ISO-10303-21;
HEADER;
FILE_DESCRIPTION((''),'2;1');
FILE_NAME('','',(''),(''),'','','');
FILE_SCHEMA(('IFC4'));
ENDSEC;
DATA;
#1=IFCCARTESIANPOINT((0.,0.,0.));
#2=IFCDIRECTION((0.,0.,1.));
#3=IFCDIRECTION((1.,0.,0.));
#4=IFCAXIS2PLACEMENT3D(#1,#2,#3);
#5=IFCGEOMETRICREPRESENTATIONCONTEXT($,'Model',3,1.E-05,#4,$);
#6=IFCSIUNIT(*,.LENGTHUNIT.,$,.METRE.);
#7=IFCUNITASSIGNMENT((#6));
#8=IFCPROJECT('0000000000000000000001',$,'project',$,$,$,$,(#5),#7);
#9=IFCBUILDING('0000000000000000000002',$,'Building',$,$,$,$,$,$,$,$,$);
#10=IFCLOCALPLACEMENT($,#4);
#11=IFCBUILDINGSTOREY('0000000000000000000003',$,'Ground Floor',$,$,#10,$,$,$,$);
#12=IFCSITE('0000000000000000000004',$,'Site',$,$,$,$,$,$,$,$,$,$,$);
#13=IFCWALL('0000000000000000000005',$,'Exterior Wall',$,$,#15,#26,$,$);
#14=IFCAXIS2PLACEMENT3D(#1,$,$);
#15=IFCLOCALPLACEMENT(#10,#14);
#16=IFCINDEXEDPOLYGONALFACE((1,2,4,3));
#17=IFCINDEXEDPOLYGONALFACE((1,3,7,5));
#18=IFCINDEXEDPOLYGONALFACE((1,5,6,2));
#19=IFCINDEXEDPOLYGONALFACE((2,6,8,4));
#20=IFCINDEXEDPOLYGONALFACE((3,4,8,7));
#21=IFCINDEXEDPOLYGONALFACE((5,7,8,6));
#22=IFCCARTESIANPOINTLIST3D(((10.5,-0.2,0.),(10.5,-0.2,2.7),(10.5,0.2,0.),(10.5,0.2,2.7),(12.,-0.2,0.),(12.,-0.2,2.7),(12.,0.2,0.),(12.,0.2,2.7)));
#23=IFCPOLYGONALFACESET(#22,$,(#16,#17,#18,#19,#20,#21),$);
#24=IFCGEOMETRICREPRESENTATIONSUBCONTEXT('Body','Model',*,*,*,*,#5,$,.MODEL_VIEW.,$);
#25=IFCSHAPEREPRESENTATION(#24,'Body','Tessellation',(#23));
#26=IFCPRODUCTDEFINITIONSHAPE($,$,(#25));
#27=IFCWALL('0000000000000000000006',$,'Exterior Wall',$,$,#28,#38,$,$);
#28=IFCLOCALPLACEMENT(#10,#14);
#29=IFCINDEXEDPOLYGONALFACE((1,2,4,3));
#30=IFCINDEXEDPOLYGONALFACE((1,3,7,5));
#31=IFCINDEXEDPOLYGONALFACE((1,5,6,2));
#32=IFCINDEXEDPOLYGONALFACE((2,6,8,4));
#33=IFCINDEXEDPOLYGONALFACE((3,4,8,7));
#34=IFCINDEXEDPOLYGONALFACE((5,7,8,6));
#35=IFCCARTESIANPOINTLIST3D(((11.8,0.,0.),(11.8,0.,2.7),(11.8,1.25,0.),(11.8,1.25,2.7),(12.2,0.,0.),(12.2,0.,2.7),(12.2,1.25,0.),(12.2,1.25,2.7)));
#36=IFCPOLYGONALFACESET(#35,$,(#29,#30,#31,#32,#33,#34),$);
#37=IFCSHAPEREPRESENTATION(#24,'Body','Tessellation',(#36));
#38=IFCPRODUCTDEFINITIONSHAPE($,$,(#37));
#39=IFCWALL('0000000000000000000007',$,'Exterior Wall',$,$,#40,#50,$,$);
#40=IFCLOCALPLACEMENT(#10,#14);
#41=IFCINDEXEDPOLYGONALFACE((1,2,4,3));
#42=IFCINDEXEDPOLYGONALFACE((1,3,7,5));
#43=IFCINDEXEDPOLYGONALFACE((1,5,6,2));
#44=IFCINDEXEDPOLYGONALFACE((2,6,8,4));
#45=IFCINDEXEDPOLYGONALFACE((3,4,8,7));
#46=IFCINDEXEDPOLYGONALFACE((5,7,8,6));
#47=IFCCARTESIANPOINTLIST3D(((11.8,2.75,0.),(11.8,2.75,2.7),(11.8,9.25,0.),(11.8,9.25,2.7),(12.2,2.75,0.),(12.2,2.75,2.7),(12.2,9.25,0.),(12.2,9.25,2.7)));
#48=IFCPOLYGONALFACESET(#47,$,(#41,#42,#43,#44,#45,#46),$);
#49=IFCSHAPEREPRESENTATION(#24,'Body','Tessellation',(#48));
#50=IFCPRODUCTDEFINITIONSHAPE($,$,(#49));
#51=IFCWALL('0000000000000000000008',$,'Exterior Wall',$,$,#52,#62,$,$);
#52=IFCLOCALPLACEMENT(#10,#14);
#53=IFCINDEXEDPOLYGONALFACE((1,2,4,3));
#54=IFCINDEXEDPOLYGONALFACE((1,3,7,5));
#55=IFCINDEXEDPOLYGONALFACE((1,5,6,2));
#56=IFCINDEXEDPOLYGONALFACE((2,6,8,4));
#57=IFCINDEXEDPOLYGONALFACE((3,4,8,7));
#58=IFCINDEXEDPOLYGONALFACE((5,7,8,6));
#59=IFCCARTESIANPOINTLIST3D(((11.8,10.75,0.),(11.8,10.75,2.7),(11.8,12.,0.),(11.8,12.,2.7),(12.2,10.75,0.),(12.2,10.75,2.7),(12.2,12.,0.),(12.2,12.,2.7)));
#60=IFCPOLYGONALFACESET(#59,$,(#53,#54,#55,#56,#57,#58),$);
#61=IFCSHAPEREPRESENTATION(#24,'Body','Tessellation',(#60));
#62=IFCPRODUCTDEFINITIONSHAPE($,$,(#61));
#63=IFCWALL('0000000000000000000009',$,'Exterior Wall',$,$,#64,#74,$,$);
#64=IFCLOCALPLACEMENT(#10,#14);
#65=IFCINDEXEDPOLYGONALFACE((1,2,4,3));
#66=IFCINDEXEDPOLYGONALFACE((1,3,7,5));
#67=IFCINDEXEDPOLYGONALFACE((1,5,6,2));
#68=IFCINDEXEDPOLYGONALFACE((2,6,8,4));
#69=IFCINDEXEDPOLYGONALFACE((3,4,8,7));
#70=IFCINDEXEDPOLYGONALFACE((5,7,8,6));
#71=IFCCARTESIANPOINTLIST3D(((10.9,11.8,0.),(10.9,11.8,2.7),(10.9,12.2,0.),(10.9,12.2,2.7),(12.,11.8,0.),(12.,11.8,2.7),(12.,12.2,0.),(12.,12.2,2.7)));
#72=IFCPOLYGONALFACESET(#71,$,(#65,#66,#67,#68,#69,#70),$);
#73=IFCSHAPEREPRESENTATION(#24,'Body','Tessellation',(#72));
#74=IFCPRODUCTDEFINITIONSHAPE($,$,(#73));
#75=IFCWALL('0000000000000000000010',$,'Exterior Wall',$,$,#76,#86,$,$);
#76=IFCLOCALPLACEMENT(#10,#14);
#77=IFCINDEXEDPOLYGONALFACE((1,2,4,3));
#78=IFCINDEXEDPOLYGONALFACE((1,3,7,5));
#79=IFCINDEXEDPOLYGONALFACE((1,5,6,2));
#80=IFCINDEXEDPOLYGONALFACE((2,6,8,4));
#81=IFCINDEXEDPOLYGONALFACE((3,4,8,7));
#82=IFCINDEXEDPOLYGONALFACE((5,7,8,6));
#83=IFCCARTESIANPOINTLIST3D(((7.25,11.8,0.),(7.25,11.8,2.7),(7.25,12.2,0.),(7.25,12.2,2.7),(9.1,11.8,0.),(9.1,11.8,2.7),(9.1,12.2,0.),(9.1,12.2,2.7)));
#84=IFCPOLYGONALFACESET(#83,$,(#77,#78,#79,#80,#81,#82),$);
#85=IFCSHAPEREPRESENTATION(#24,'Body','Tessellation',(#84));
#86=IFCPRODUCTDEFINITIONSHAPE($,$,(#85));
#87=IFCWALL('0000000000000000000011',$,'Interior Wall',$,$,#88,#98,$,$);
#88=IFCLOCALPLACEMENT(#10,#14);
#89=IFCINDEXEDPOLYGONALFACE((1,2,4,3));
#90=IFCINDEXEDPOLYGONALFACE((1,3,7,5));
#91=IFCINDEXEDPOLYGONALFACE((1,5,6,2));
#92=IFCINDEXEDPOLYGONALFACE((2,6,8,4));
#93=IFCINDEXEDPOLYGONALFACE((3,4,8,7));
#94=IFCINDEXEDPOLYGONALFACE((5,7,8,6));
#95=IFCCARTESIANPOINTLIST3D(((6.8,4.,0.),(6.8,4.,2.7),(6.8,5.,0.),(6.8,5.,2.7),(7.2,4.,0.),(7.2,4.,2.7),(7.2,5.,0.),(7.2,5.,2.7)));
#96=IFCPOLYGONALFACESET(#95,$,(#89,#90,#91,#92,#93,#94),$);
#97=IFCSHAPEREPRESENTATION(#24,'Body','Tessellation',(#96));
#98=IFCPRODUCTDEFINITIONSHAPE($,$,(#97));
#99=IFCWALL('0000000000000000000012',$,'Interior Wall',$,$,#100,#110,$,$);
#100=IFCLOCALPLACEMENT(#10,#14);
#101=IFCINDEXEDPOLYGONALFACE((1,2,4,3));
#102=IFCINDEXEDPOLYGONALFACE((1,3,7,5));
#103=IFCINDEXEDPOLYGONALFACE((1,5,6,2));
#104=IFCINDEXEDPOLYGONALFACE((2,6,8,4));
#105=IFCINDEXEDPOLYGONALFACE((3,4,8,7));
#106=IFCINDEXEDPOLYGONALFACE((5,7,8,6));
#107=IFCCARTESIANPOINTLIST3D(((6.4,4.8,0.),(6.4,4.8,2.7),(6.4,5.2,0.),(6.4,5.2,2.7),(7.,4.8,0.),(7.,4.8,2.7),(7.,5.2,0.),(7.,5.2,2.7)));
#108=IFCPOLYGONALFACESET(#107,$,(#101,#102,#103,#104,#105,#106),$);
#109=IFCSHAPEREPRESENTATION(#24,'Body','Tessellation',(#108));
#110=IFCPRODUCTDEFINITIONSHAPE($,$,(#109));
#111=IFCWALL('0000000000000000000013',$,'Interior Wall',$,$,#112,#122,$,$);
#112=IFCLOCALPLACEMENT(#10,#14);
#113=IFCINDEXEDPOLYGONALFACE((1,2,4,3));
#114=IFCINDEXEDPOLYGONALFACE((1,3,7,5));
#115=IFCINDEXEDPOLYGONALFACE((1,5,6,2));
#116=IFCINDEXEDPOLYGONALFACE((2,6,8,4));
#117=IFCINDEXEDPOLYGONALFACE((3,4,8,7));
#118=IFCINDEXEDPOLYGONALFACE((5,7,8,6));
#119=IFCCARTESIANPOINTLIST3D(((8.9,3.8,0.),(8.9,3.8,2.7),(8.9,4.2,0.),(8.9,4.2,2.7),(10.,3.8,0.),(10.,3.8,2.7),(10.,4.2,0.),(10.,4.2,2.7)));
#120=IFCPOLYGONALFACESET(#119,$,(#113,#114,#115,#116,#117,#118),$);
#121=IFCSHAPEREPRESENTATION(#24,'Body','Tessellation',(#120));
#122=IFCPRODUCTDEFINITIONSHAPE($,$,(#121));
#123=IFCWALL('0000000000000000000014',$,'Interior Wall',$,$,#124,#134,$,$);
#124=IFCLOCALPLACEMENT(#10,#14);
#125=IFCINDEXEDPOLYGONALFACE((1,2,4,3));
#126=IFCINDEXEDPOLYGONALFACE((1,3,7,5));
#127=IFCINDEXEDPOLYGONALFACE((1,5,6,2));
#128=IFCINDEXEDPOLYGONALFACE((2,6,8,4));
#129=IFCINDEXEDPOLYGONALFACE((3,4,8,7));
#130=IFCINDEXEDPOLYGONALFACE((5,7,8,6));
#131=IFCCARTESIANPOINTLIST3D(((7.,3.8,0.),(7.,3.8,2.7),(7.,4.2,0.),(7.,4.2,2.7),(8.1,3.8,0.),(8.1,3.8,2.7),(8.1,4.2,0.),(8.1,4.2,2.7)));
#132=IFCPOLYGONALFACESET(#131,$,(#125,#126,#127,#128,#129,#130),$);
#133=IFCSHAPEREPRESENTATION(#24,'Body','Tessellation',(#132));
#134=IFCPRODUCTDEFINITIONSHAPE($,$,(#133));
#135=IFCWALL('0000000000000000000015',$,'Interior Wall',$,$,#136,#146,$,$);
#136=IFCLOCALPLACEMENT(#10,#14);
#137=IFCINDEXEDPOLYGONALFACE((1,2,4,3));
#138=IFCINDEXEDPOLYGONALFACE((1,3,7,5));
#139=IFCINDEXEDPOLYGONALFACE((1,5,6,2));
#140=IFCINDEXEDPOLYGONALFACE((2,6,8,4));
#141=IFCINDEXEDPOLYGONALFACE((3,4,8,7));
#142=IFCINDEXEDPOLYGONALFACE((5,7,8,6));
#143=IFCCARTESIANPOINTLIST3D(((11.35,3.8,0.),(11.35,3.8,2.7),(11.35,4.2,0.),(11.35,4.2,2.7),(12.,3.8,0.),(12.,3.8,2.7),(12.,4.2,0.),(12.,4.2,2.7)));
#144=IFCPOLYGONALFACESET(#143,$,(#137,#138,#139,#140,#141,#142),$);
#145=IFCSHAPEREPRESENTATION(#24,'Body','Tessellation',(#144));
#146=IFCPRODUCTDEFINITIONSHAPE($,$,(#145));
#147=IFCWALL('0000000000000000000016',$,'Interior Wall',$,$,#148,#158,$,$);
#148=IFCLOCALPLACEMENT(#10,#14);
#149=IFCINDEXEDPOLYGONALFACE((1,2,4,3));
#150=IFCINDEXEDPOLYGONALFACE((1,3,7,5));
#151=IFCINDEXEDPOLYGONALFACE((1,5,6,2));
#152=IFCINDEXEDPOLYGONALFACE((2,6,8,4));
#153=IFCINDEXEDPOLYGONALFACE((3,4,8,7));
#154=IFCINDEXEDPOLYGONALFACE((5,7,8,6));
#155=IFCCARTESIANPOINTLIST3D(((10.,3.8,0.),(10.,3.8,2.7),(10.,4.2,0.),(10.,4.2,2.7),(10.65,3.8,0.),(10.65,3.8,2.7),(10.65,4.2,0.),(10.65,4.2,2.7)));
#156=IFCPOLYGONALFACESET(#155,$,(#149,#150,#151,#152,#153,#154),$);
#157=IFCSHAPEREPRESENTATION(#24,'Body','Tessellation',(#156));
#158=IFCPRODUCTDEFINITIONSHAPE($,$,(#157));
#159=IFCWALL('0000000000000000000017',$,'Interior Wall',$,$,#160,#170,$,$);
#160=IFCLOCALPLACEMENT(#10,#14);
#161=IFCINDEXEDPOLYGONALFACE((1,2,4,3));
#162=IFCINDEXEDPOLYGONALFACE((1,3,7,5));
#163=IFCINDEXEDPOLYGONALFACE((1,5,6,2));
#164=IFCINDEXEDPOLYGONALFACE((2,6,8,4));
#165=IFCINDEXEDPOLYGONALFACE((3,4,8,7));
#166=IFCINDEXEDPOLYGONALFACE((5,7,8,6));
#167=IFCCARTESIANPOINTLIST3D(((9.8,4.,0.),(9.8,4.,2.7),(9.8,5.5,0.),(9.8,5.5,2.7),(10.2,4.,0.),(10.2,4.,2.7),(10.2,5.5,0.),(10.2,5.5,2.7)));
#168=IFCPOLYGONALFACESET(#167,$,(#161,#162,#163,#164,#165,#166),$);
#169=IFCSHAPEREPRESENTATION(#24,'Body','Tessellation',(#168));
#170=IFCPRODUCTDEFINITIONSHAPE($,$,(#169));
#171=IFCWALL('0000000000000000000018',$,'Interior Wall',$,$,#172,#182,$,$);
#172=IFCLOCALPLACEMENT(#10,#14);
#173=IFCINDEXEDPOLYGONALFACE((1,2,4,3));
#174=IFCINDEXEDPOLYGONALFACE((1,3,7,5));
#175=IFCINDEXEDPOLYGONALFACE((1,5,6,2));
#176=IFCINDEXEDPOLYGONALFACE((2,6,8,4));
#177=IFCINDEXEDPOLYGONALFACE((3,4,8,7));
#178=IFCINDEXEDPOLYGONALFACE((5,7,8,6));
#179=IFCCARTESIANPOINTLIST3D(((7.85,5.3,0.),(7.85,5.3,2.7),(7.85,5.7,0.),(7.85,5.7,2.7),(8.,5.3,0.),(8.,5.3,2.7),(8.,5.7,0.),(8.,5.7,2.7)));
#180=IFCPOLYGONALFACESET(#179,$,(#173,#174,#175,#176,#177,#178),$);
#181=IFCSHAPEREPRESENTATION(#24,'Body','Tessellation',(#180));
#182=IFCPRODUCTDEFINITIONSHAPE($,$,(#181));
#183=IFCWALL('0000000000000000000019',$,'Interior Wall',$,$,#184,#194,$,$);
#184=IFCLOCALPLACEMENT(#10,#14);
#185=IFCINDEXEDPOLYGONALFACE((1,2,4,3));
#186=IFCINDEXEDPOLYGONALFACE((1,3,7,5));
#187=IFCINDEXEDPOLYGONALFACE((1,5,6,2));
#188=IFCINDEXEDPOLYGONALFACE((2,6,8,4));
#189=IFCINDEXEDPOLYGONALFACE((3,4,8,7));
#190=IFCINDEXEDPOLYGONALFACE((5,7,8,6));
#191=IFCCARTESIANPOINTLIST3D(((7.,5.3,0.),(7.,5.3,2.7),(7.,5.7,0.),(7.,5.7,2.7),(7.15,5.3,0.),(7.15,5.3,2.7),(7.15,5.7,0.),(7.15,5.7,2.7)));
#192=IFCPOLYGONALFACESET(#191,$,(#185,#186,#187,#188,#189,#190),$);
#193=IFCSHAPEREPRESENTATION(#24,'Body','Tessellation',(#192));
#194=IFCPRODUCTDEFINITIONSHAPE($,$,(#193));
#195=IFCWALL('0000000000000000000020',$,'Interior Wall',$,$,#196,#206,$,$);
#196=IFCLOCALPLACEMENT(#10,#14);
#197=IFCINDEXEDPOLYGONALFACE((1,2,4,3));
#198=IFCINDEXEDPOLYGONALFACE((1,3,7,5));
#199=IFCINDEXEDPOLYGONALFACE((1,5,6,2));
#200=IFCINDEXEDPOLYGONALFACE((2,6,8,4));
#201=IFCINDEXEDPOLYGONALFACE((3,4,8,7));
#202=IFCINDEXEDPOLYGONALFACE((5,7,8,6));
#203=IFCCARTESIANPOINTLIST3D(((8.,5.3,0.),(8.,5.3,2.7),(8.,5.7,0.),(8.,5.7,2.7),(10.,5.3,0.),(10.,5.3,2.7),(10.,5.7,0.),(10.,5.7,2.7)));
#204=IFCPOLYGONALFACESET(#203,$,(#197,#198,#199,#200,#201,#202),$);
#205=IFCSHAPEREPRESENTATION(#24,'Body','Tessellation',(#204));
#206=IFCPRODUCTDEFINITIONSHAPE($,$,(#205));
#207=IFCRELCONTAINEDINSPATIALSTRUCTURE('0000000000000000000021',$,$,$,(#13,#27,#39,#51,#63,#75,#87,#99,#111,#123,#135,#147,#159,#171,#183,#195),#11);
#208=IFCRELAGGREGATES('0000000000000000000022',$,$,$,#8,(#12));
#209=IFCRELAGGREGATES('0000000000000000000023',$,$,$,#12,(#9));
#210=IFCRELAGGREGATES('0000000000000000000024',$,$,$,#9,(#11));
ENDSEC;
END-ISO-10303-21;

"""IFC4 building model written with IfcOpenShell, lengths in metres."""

from ifc_helpers import new_model, si_unit, frame, origin_with_axes, place, context, subcontext, project, spatial, indexed_curve, outline, extrude, element, save


model = new_model("IFC4")

# Units and contexts
model_context = context("Model", 3, precision=1e-05, world=origin_with_axes())
body_context = subcontext(model_context, "Body", "Model", "MODEL_VIEW")
ifc_project = project(units=[si_unit("LENGTHUNIT", "METRE")], contexts=[model_context])

# Site, building, storey
site = spatial("IfcSite", under=ifc_project, Name="Site")
building = spatial("IfcBuilding", under=site, Name="Building")
storey_placement = place(None, origin_with_axes())
storey = spatial("IfcBuildingStorey", under=building, at=storey_placement, Name="Ground Floor")

# Walls
wall_1_placement = place(storey_placement, frame((10.5, 0.0, 0.0), z_axis=(0.0, 0.0, 1.0), x_axis=(1.0, 0.0, 0.0)))
element("IfcWall", 1, at=wall_1_placement, inside=storey, Name="Exterior Wall", context=body_context, shape_type="SweptSolid", body=[
    extrude(outline(indexed_curve([(0.0, 0.0), (0.0, 0.4), (1.5, 0.4), (1.5, 0.0), (0.0, 0.0)], self_intersect=False)), frame((0.0, -0.2, 0.0), z_axis=(0.0, 0.0, 1.0), x_axis=(1.0, 0.0, 0.0)), (0.0, 0.0, 1.0), 2.7),
])
wall_2_placement = place(storey_placement, frame((12.0, 0.0, 0.0), z_axis=(0.0, 0.0, 1.0), x_axis=(0.0, 1.0, 0.0)))
element("IfcWall", 2, at=wall_2_placement, inside=storey, Name="Exterior Wall", context=body_context, shape_type="SweptSolid", body=[
    extrude(outline(indexed_curve([(0.0, 0.0), (0.0, 0.4), (1.25, 0.4), (1.25, 0.0), (0.0, 0.0)], self_intersect=False)), frame((0.0, -0.2, 0.0), z_axis=(0.0, 0.0, 1.0), x_axis=(1.0, 0.0, 0.0)), (0.0, 0.0, 1.0), 2.7),
])
wall_3_placement = place(storey_placement, frame((12.0, 2.75, 0.0), z_axis=(0.0, 0.0, 1.0), x_axis=(0.0, 1.0, 0.0)))
element("IfcWall", 3, at=wall_3_placement, inside=storey, Name="Exterior Wall", context=body_context, shape_type="SweptSolid", body=[
    extrude(outline(indexed_curve([(0.0, 0.0), (0.0, 0.4), (6.5, 0.4), (6.5, 0.0), (0.0, 0.0)], self_intersect=False)), frame((0.0, -0.2, 0.0), z_axis=(0.0, 0.0, 1.0), x_axis=(1.0, 0.0, 0.0)), (0.0, 0.0, 1.0), 2.7),
])
wall_4_placement = place(storey_placement, frame((12.0, 10.75, 0.0), z_axis=(0.0, 0.0, 1.0), x_axis=(0.0, 1.0, 0.0)))
element("IfcWall", 4, at=wall_4_placement, inside=storey, Name="Exterior Wall", context=body_context, shape_type="SweptSolid", body=[
    extrude(outline(indexed_curve([(0.0, 0.0), (0.0, 0.4), (1.25, 0.4), (1.25, 0.0), (0.0, 0.0)], self_intersect=False)), frame((0.0, -0.2, 0.0), z_axis=(0.0, 0.0, 1.0), x_axis=(1.0, 0.0, 0.0)), (0.0, 0.0, 1.0), 2.7),
])
wall_5_placement = place(storey_placement, frame((12.0, 12.0, 0.0), z_axis=(0.0, 0.0, 1.0), x_axis=(-1.0, 0.0, 0.0)))
element("IfcWall", 5, at=wall_5_placement, inside=storey, Name="Exterior Wall", context=body_context, shape_type="SweptSolid", body=[
    extrude(outline(indexed_curve([(0.0, 0.0), (0.0, 0.4), (1.1, 0.4), (1.1, 0.0), (0.0, 0.0)], self_intersect=False)), frame((0.0, -0.2, 0.0), z_axis=(0.0, 0.0, 1.0), x_axis=(1.0, 0.0, 0.0)), (0.0, 0.0, 1.0), 2.7),
])
wall_6_placement = place(storey_placement, frame((9.1, 12.0, 0.0), z_axis=(0.0, 0.0, 1.0), x_axis=(-1.0, 0.0, 0.0)))
element("IfcWall", 6, at=wall_6_placement, inside=storey, Name="Exterior Wall", context=body_context, shape_type="SweptSolid", body=[
    extrude(outline(indexed_curve([(0.0, 0.0), (0.0, 0.4), (1.85, 0.4), (1.85, 0.0), (0.0, 0.0)], self_intersect=False)), frame((0.0, -0.2, 0.0), z_axis=(0.0, 0.0, 1.0), x_axis=(1.0, 0.0, 0.0)), (0.0, 0.0, 1.0), 2.7),
])
wall_7_placement = place(storey_placement, frame((7.0, 4.0, 0.0), z_axis=(0.0, 0.0, 1.0), x_axis=(0.0, 1.0, 0.0)))
element("IfcWall", 7, at=wall_7_placement, inside=storey, Name="Interior Wall", context=body_context, shape_type="SweptSolid", body=[
    extrude(outline(indexed_curve([(0.0, 0.0), (0.0, 0.4), (1.0, 0.4), (1.0, 0.0), (0.0, 0.0)], self_intersect=False)), frame((0.0, -0.2, 0.0), z_axis=(0.0, 0.0, 1.0), x_axis=(1.0, 0.0, 0.0)), (0.0, 0.0, 1.0), 2.7),
])
wall_8_placement = place(storey_placement, frame((7.0, 5.0, 0.0), z_axis=(0.0, 0.0, 1.0), x_axis=(-1.0, 0.0, 0.0)))
element("IfcWall", 8, at=wall_8_placement, inside=storey, Name="Interior Wall", context=body_context, shape_type="SweptSolid", body=[
    extrude(outline(indexed_curve([(0.0, 0.0), (0.0, 0.4), (0.6, 0.4), (0.6, 0.0), (0.0, 0.0)], self_intersect=False)), frame((0.0, -0.2, 0.0), z_axis=(0.0, 0.0, 1.0), x_axis=(1.0, 0.0, 0.0)), (0.0, 0.0, 1.0), 2.7),
])
for number, where, z_axis, x_axis, name in (
    (9, (10.0, 4.0, 0.0), (0.0, 0.0, 1.0), (-1.0, 0.0, 0.0), "Interior Wall"),
    (10, (8.1, 4.0, 0.0), (0.0, 0.0, 1.0), (-1.0, 0.0, 0.0), "Interior Wall"),
):
    element("IfcWall", number, at=place(storey_placement, frame(where, z_axis=z_axis, x_axis=x_axis)), inside=storey, Name=name, context=body_context, shape_type="SweptSolid", body=[
        extrude(outline(indexed_curve([(0.0, 0.0), (0.0, 0.4), (1.1, 0.4), (1.1, 0.0), (0.0, 0.0)], self_intersect=False)), frame((0.0, -0.2, 0.0), z_axis=(0.0, 0.0, 1.0), x_axis=(1.0, 0.0, 0.0)), (0.0, 0.0, 1.0), 2.7),
    ])
for number, where, z_axis, x_axis, name in (
    (11, (12.0, 4.0, 0.0), (0.0, 0.0, 1.0), (-1.0, 0.0, 0.0), "Interior Wall"),
    (12, (10.65, 4.0, 0.0), (0.0, 0.0, 1.0), (-1.0, 0.0, 0.0), "Interior Wall"),
):
    element("IfcWall", number, at=place(storey_placement, frame(where, z_axis=z_axis, x_axis=x_axis)), inside=storey, Name=name, context=body_context, shape_type="SweptSolid", body=[
        extrude(outline(indexed_curve([(0.0, 0.0), (0.0, 0.4), (0.65, 0.4), (0.65, 0.0), (0.0, 0.0)], self_intersect=False)), frame((0.0, -0.2, 0.0), z_axis=(0.0, 0.0, 1.0), x_axis=(1.0, 0.0, 0.0)), (0.0, 0.0, 1.0), 2.7),
    ])
wall_9_placement = place(storey_placement, frame((10.0, 4.0, 0.0), z_axis=(0.0, 0.0, 1.0), x_axis=(0.0, 1.0, 0.0)))
element("IfcWall", 13, at=wall_9_placement, inside=storey, Name="Interior Wall", context=body_context, shape_type="SweptSolid", body=[
    extrude(outline(indexed_curve([(0.0, 0.0), (0.0, 0.4), (1.5, 0.4), (1.5, 0.0), (0.0, 0.0)], self_intersect=False)), frame((0.0, -0.2, 0.0), z_axis=(0.0, 0.0, 1.0), x_axis=(1.0, 0.0, 0.0)), (0.0, 0.0, 1.0), 2.7),
])
for number, where, z_axis, x_axis, name in (
    (14, (8.0, 5.5, 0.0), (0.0, 0.0, 1.0), (-1.0, 0.0, 0.0), "Interior Wall"),
    (15, (7.15, 5.5, 0.0), (0.0, 0.0, 1.0), (-1.0, 0.0, 0.0), "Interior Wall"),
):
    element("IfcWall", number, at=place(storey_placement, frame(where, z_axis=z_axis, x_axis=x_axis)), inside=storey, Name=name, context=body_context, shape_type="SweptSolid", body=[
        extrude(outline(indexed_curve([(0.0, 0.0), (0.0, 0.4), (0.15, 0.4), (0.15, 0.0), (0.0, 0.0)], self_intersect=False)), frame((0.0, -0.2, 0.0), z_axis=(0.0, 0.0, 1.0), x_axis=(1.0, 0.0, 0.0)), (0.0, 0.0, 1.0), 2.7),
    ])
wall_10_placement = place(storey_placement, frame((10.0, 5.5, 0.0), z_axis=(0.0, 0.0, 1.0), x_axis=(-1.0, 0.0, 0.0)))
element("IfcWall", 16, at=wall_10_placement, inside=storey, Name="Interior Wall", context=body_context, shape_type="SweptSolid", body=[
    extrude(outline(indexed_curve([(0.0, 0.0), (0.0, 0.4), (2.0, 0.4), (2.0, 0.0), (0.0, 0.0)], self_intersect=False)), frame((0.0, -0.2, 0.0), z_axis=(0.0, 0.0, 1.0), x_axis=(1.0, 0.0, 0.0)), (0.0, 0.0, 1.0), 2.7),
])

save(model, "model.ifc")
